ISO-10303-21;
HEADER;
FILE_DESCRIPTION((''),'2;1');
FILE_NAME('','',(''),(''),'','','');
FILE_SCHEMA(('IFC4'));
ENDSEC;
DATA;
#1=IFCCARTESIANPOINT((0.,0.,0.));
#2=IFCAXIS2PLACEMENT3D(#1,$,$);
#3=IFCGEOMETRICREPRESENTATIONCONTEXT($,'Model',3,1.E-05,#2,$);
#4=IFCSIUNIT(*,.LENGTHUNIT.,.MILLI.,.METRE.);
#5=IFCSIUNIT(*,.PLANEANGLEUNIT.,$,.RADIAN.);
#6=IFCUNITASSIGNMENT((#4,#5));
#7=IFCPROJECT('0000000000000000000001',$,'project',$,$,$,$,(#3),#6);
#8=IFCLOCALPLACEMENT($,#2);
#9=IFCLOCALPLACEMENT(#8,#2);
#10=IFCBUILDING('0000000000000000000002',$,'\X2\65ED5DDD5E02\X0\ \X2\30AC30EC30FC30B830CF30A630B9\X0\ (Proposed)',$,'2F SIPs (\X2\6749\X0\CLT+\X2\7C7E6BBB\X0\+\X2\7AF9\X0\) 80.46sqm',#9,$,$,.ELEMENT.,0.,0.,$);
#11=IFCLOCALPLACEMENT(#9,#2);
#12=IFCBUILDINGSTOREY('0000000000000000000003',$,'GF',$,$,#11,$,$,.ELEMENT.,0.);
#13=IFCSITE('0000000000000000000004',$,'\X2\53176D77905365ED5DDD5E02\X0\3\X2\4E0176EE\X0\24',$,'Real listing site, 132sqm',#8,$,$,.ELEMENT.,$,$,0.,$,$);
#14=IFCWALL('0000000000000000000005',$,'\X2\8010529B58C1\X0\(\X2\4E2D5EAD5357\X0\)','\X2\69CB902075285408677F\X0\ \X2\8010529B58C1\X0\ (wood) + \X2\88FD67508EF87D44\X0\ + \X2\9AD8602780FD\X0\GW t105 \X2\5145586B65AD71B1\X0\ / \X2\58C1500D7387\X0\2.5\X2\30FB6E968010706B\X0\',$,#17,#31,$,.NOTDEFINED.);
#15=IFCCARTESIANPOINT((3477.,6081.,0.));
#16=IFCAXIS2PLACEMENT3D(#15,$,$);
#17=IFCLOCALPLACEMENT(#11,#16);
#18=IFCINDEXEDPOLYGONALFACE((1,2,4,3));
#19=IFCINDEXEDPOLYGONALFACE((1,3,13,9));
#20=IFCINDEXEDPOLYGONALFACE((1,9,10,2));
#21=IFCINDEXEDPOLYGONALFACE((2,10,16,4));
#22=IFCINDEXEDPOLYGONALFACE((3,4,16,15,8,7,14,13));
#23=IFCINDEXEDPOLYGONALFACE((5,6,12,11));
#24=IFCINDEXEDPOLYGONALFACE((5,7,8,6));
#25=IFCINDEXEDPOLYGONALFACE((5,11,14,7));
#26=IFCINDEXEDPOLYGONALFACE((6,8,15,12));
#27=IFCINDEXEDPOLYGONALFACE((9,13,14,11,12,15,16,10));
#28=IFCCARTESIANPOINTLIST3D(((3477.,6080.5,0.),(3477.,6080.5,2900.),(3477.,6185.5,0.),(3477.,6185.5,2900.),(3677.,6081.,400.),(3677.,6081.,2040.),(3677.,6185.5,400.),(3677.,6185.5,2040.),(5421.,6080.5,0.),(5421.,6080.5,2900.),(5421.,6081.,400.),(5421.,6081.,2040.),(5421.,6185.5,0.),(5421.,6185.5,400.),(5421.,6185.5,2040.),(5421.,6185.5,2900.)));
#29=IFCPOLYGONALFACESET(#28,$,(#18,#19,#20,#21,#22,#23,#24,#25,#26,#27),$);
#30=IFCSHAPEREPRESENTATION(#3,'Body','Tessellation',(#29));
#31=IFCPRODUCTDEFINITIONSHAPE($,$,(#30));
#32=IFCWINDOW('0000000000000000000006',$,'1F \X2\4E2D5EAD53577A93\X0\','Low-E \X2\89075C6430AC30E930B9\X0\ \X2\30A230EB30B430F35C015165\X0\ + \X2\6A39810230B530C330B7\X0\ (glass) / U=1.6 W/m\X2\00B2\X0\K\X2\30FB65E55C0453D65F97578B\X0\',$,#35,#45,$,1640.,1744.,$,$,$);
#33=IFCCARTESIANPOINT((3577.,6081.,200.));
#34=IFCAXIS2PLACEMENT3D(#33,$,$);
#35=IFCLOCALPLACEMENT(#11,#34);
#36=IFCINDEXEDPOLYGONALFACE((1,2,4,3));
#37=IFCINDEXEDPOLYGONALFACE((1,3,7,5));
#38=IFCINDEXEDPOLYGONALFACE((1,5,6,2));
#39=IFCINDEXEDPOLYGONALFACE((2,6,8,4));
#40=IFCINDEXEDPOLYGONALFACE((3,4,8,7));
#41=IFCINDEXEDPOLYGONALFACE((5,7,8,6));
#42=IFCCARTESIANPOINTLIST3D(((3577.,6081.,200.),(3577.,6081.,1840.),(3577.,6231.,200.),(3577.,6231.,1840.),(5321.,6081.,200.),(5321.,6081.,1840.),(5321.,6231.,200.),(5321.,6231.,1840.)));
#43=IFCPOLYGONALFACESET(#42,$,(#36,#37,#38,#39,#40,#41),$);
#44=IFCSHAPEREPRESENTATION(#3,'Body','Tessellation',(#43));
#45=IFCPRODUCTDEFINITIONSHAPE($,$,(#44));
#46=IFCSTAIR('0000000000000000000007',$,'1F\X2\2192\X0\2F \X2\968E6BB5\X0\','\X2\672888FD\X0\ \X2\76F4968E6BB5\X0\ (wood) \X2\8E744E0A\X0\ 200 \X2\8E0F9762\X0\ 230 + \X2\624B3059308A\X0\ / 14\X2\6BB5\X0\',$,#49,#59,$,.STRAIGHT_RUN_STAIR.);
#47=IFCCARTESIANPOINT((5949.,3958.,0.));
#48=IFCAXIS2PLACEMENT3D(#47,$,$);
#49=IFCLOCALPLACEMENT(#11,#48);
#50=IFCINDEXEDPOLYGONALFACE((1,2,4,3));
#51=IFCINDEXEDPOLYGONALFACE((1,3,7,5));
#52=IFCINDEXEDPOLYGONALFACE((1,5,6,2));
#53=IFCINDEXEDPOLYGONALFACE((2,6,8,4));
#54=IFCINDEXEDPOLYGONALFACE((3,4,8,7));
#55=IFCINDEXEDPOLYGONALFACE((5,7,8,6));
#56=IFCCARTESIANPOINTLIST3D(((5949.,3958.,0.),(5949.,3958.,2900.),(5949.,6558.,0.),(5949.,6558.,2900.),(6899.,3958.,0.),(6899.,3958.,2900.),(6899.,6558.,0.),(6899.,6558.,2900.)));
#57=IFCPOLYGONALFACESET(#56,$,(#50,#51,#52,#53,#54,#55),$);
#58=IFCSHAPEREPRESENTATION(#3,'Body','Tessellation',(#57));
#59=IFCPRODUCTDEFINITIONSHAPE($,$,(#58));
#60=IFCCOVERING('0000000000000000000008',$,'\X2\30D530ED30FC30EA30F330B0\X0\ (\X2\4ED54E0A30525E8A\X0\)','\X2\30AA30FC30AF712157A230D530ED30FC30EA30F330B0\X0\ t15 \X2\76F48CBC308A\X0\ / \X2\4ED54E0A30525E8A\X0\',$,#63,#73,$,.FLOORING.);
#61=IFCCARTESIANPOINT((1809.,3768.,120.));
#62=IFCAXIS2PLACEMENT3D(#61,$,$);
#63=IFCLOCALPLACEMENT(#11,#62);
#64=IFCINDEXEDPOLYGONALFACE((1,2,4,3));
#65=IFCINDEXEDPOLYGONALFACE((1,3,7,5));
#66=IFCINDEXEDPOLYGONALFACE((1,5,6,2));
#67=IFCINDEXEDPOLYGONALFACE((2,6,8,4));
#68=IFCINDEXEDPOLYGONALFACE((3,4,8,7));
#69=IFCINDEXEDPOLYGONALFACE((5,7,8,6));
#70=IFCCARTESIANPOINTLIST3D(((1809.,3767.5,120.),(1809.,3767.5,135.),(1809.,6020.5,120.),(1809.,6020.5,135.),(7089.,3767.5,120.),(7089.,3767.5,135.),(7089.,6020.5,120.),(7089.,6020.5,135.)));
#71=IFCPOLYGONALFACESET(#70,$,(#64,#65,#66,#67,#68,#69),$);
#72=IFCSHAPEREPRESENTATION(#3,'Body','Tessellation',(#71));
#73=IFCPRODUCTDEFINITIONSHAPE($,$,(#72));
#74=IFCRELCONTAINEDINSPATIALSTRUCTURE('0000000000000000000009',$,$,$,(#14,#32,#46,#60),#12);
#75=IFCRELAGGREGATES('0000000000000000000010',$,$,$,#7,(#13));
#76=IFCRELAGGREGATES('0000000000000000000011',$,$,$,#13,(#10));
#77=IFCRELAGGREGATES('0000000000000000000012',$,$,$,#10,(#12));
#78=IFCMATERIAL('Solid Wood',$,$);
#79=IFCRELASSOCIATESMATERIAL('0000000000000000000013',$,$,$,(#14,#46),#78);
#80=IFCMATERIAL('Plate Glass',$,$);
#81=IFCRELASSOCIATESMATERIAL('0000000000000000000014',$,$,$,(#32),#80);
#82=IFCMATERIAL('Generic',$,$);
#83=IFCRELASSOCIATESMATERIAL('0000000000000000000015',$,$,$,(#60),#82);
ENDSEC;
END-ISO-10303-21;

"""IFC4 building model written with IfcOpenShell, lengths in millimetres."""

from ifc_helpers import new_model, si_unit, frame, frame_2d, origin, place, context, project, spatial, rectangle, extrude, material, element, fill, save


model = new_model("IFC4")

# Units and contexts
model_context = context("Model", 3, precision=1e-05, world=origin())
ifc_project = project(units=[si_unit("LENGTHUNIT", "METRE", prefix="MILLI"), si_unit("PLANEANGLEUNIT", "RADIAN")], contexts=[model_context])

# Site, building, storey
site_placement = place(None, origin())
site = spatial("IfcSite", under=ifc_project, at=site_placement, Name="北海道旭川市3丁目24", ObjectType="Real listing site, 132sqm", CompositionType="ELEMENT", RefElevation=0.0)
building_placement = place(site_placement, origin())
building = spatial("IfcBuilding", under=site, at=building_placement, Name="旭川市 ガレージハウス (Proposed)", ObjectType="2F SIPs (杉CLT+籾殻+竹) 80.46sqm", CompositionType="ELEMENT", ElevationOfRefHeight=0.0, ElevationOfTerrain=0.0)
storey_placement = place(building_placement, origin())
storey = spatial("IfcBuildingStorey", under=building, at=storey_placement, Name="GF", CompositionType="ELEMENT", Elevation=0.0)

# Shared definitions
ifc_material_1 = material(Name="Solid Wood")
ifc_material_2 = material(Name="Generic")

# Shared definitions
ifc_material_3 = material(Name="Plate Glass")

# Wall, opening, window
wall_1_placement = place(storey_placement, frame((3477.0, 6081.0, 0.0)))
wall_1 = element("IfcWall", 1, at=wall_1_placement, inside=storey, material=ifc_material_1, Name="耐力壁(中庭南)", Description="構造用合板 耐力壁 (wood) + 製材軸組 + 高性能GW t105 充填断熱 / 壁倍率2.5・準耐火", PredefinedType="NOTDEFINED", context=model_context, shape_type="SweptSolid", body=[
    extrude(rectangle(XDim=1944.0, YDim=105.0, at=frame_2d((972.0, 52.0))), frame((3477.0, 6081.0, 0.0)), (0.0, 0.0, 1.0), 2900.0),
])
opening_1_placement = place(storey_placement, frame((3577.0, 6081.0, 200.0)))
opening_1 = element("IfcOpeningElement", 2, at=opening_1_placement, cuts=wall_1, PredefinedType="NOTDEFINED", context=model_context, shape_type="SweptSolid", body=[
    extrude(rectangle(XDim=1744.0, YDim=150.0, at=frame_2d((872.0, 75.0))), frame((3577.0, 6081.0, 200.0)), (0.0, 0.0, 1.0), 1640.0),
])
window_1_placement = place(storey_placement, frame((3577.0, 6081.0, 200.0)))
window_1 = element("IfcWindow", 3, at=window_1_placement, inside=storey, material=ifc_material_3, Name="1F 中庭南窓", Description="Low-E 複層ガラス アルゴン封入 + 樹脂サッシ (glass) / U=1.6 W/m²K・日射取得型", OverallHeight=1640.0, OverallWidth=1744.0, context=model_context, shape_type="SweptSolid", body=[
    extrude(rectangle(XDim=1744.0, YDim=150.0, at=frame_2d((872.0, 75.0))), frame((3577.0, 6081.0, 200.0)), (0.0, 0.0, 1.0), 1640.0),
])
fill(opening_1, window_1)

# Stair
stair_placement = place(storey_placement, frame((5949.0, 3958.0, 0.0)))
element("IfcStair", 4, at=stair_placement, inside=storey, material=ifc_material_1, Name="1F→2F 階段", Description="木製 直階段 (wood) 蹴上 200 踏面 230 + 手すり / 14段", PredefinedType="STRAIGHT_RUN_STAIR", context=model_context, shape_type="SweptSolid", body=[
    extrude(rectangle(XDim=950.0, YDim=2600.0, at=frame_2d((475.0, 1300.0))), frame((5949.0, 3958.0, 0.0)), (0.0, 0.0, 1.0), 2900.0),
])

# Covering
covering_placement = place(storey_placement, frame((1809.0, 3768.0, 120.0)))
element("IfcCovering", 5, at=covering_placement, inside=storey, material=ifc_material_2, Name="フローリング (仕上げ床)", Description="オーク無垢フローリング t15 直貼り / 仕上げ床", PredefinedType="FLOORING", context=model_context, shape_type="SweptSolid", body=[
    extrude(rectangle(XDim=5280.0, YDim=2253.0, at=frame_2d((2640.0, 1126.0))), frame((1809.0, 3768.0, 120.0)), (0.0, 0.0, 1.0), 15.0),
])

save(model, "model.ifc")
